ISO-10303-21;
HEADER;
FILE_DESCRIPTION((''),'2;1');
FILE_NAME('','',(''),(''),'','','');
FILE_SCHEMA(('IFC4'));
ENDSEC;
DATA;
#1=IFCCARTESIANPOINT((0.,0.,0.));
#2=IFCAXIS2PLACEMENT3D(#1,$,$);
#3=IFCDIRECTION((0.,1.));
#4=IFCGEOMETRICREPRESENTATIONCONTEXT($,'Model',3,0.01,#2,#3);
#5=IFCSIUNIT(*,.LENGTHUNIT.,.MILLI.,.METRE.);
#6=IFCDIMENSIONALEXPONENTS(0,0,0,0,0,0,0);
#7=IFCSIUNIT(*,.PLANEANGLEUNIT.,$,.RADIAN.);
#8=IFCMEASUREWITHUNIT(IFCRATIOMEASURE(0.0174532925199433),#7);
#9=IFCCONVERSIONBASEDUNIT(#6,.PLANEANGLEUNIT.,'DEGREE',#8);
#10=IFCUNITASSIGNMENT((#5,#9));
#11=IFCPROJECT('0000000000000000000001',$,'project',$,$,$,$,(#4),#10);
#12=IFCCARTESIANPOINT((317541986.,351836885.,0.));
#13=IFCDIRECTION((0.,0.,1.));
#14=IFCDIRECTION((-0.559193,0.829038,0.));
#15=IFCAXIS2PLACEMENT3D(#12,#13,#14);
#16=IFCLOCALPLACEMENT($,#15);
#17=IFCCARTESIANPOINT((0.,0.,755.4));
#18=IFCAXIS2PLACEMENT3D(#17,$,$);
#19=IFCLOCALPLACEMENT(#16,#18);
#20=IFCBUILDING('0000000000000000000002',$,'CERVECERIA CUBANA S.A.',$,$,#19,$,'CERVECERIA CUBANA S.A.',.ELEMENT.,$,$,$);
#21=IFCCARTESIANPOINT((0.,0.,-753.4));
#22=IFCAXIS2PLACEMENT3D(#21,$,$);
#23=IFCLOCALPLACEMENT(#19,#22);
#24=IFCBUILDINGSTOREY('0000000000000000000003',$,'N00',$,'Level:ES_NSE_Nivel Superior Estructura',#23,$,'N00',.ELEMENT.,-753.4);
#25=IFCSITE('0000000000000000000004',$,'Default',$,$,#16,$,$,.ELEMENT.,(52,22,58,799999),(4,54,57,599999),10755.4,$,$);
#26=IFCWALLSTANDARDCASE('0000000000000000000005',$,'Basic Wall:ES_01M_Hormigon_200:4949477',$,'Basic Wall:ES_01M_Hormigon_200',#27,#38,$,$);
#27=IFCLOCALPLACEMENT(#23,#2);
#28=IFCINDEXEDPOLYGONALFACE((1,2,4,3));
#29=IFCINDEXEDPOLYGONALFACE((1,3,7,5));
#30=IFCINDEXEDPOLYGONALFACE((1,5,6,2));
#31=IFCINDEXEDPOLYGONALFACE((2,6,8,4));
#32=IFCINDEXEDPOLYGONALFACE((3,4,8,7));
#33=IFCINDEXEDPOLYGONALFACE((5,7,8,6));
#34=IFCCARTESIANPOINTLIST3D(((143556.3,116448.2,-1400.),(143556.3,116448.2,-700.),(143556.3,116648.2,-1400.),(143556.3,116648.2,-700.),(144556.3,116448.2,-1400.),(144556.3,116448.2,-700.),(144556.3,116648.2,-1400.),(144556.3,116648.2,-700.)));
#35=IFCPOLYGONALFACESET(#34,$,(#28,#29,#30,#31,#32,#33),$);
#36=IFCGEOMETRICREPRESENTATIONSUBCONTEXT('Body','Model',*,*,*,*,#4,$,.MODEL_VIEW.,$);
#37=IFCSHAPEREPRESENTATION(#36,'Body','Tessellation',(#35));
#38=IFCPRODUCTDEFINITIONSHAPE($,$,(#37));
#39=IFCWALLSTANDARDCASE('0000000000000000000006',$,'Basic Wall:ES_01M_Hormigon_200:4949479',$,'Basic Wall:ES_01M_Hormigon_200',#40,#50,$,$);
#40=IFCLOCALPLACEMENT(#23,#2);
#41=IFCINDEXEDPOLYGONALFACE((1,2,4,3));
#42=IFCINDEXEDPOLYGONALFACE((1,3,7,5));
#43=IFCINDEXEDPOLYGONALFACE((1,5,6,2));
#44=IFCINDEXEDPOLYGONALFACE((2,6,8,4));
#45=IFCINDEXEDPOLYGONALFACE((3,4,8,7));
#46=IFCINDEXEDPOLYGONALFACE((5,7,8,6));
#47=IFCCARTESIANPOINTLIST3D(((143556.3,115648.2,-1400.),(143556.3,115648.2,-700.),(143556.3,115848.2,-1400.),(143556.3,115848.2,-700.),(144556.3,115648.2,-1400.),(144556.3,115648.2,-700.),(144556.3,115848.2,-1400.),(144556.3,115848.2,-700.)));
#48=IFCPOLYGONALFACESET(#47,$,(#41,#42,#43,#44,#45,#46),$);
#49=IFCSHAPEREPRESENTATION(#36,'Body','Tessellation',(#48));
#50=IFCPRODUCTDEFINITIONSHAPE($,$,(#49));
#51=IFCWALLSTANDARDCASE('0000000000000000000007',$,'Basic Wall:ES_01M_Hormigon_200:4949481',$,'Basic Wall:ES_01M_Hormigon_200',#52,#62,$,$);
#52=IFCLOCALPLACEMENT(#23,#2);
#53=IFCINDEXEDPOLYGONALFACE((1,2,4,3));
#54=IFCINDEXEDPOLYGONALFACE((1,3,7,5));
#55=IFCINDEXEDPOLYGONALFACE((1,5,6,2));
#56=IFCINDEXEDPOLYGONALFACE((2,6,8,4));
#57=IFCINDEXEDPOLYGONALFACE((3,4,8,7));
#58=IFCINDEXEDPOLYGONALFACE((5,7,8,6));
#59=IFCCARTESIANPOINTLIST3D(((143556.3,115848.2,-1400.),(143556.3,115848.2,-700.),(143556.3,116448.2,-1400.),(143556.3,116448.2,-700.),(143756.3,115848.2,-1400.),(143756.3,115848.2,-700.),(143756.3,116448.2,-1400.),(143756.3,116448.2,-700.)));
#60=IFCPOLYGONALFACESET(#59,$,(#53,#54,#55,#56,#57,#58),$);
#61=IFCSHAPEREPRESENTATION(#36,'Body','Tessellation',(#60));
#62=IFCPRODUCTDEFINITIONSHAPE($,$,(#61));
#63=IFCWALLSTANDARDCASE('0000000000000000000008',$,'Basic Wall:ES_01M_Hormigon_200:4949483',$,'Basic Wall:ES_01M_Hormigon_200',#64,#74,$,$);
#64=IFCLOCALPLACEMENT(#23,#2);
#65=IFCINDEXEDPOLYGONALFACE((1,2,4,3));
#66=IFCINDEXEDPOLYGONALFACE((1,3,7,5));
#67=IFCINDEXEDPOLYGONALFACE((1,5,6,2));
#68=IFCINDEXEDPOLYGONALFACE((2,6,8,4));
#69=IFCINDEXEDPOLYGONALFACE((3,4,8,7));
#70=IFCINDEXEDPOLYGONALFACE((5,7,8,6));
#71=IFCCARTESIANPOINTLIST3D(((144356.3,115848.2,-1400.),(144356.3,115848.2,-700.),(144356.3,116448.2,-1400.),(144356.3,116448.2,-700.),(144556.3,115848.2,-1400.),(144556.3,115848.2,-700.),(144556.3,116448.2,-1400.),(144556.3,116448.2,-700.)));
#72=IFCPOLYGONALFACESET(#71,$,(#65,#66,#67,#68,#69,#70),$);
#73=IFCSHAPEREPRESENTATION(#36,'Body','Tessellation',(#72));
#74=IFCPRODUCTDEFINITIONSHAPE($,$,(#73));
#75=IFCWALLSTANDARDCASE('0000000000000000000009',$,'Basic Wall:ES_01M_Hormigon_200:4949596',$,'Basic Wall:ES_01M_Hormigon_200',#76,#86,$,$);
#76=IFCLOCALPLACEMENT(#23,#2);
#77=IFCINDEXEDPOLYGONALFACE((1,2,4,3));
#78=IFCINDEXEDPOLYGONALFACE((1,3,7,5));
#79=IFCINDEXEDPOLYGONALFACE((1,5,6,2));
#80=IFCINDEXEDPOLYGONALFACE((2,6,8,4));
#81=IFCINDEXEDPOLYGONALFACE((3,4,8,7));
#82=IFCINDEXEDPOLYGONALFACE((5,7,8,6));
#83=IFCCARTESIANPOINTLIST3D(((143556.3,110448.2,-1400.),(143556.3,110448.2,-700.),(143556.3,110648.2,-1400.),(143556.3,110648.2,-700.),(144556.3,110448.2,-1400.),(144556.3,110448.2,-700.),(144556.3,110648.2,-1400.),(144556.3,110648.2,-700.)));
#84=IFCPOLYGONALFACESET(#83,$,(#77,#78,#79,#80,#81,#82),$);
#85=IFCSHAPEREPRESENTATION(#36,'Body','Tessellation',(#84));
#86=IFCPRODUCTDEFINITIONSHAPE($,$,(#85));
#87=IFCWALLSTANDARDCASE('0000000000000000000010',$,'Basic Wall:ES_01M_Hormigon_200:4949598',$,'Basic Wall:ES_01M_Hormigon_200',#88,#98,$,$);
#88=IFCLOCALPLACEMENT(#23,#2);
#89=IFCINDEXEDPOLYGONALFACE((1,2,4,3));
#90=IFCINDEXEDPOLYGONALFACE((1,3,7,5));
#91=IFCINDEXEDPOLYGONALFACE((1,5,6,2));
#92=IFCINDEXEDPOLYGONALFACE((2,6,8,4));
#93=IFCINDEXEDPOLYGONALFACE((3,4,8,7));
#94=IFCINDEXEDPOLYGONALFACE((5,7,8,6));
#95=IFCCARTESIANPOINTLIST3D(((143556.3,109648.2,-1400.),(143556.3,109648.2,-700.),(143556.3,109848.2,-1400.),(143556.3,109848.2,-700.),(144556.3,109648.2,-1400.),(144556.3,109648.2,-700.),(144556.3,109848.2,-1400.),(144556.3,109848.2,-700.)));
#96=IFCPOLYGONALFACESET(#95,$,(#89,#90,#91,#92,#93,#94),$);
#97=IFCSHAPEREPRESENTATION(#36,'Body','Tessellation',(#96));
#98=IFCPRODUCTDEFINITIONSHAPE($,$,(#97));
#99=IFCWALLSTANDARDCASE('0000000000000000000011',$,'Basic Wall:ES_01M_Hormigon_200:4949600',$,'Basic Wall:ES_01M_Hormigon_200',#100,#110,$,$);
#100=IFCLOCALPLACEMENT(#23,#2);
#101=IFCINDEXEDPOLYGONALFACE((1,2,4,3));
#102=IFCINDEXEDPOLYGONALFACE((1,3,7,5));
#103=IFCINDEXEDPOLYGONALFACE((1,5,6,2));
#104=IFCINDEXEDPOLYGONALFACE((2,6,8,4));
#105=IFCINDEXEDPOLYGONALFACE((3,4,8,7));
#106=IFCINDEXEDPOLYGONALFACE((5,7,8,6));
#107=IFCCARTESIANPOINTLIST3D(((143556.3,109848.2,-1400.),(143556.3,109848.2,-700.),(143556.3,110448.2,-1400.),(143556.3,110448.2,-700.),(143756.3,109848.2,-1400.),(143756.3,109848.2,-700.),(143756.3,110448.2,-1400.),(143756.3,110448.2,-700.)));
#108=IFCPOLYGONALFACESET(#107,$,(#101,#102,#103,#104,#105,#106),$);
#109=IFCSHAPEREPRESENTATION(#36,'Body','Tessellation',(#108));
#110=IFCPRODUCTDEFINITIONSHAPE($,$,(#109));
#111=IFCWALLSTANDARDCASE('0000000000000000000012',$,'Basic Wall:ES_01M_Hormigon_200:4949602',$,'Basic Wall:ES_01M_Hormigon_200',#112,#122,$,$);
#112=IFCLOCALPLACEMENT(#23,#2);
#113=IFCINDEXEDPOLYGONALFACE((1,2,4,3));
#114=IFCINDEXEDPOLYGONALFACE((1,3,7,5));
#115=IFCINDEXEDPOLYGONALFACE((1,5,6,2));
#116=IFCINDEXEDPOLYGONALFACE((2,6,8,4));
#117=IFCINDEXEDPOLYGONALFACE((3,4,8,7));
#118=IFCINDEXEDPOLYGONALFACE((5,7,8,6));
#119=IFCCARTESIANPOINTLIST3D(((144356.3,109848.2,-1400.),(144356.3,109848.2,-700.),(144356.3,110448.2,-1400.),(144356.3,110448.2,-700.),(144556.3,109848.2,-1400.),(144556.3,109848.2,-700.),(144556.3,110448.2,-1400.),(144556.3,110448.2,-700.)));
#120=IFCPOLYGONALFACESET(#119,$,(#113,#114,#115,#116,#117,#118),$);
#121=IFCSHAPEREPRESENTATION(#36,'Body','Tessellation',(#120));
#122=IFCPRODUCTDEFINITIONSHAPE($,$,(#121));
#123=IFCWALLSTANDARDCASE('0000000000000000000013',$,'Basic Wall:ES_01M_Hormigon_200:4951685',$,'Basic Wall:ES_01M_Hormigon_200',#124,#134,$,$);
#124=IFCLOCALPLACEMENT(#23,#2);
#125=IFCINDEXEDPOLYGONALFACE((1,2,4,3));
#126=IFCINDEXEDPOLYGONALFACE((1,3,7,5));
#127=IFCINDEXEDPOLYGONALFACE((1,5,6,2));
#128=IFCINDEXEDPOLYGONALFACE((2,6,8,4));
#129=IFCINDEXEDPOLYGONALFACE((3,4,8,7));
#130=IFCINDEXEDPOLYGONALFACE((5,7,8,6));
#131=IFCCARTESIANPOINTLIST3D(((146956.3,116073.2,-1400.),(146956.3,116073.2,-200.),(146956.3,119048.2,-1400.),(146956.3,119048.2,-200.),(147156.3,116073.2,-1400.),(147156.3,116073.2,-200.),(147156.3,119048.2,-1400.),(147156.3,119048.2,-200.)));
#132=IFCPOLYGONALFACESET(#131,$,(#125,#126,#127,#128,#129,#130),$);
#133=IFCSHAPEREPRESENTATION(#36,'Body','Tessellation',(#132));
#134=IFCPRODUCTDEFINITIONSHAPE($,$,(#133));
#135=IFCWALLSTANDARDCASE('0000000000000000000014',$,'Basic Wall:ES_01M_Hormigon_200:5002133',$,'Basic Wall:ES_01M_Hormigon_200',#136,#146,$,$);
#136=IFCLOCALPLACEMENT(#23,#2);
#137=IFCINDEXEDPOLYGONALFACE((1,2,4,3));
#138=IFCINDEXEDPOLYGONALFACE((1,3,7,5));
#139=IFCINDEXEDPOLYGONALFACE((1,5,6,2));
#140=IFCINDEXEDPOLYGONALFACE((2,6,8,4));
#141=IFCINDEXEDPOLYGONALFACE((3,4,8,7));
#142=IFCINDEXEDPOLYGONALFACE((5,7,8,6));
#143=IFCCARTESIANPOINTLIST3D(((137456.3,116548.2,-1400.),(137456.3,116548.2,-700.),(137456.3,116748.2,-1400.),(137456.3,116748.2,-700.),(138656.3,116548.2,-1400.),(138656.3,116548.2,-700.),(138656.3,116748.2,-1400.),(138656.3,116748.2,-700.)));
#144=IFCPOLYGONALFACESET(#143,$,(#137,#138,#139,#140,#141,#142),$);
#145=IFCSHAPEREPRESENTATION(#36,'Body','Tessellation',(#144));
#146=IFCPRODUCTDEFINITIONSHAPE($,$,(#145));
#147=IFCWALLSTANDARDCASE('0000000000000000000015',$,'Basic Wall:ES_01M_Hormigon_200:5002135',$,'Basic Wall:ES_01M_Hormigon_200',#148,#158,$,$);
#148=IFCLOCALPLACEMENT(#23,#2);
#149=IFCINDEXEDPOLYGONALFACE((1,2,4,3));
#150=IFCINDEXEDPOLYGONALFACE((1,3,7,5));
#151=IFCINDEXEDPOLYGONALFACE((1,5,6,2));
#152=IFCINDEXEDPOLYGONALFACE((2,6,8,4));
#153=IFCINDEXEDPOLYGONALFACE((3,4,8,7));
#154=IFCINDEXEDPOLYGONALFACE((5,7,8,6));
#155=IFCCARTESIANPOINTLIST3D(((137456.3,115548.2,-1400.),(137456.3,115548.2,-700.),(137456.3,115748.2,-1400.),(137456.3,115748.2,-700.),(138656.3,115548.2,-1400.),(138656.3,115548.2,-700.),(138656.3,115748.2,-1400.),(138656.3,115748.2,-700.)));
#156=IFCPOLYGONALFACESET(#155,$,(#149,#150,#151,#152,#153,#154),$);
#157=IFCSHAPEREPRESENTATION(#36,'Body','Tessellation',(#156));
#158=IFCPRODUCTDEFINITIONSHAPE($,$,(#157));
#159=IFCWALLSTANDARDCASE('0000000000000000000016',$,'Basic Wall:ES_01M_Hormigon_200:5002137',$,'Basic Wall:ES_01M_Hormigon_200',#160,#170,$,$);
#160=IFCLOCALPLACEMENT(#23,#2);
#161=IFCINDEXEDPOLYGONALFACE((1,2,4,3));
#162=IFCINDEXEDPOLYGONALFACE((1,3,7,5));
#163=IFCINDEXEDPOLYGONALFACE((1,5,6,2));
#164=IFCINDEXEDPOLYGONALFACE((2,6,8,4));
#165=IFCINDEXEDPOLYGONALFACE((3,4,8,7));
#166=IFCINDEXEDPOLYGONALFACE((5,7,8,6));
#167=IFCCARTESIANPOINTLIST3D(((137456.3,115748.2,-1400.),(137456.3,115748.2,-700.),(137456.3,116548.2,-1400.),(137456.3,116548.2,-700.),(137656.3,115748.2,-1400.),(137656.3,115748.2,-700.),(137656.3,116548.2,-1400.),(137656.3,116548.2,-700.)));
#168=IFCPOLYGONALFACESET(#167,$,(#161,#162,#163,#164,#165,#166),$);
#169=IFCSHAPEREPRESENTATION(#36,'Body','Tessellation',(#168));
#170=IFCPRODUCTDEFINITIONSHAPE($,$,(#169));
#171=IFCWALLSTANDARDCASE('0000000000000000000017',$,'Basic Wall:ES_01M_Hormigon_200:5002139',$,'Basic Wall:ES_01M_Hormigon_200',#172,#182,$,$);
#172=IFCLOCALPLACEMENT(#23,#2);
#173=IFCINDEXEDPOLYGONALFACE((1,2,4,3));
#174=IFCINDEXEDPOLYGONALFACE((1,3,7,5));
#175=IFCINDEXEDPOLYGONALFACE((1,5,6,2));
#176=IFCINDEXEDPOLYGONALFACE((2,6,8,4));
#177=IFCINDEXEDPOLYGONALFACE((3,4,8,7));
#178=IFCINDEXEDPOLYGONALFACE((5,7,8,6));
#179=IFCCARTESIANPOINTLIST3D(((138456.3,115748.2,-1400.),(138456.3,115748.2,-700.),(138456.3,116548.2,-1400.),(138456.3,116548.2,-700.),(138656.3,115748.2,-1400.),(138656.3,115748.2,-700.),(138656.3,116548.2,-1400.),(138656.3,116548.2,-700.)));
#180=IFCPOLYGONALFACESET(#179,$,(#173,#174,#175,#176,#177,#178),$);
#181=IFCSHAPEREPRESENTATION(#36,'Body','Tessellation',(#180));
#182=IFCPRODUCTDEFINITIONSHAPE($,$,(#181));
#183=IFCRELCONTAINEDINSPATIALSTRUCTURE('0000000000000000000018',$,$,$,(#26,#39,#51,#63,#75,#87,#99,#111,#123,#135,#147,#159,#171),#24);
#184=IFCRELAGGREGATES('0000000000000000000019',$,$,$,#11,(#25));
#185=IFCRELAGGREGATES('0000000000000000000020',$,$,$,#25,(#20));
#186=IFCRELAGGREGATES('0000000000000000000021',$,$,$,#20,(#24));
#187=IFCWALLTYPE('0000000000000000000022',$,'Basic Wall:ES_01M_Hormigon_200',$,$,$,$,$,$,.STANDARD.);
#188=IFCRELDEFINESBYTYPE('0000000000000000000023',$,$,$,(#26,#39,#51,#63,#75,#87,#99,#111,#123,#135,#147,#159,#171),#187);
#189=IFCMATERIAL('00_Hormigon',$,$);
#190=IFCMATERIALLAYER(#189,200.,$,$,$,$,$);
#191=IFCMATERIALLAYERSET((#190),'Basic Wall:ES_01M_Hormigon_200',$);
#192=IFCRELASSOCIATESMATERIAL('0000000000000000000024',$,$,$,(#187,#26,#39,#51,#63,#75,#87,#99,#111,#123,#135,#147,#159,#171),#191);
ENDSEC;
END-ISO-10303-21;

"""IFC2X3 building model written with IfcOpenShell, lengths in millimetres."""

from ifc_helpers import new_model, entity, si_unit, converted_unit, direction, frame, frame_2d, origin, place, context, subcontext, project, spatial, polyline, rectangle, extrude, clip, bounded_halfspace, material, layer, layer_set, layer_usage, type_object, element, save


model = new_model("IFC2X3")

# Units and contexts
model_context = context("Model", 3, precision=0.01, world=origin(), true_north=direction((0.0, 1.0)))
body_context = subcontext(model_context, "Body", "Model", "MODEL_VIEW")
ifc_project = project(units=[si_unit("LENGTHUNIT", "METRE", prefix="MILLI"), converted_unit("PLANEANGLEUNIT", "DEGREE", entity("IfcRatioMeasure", 0.0174532925199433), si_unit("PLANEANGLEUNIT", "RADIAN"), dimensions=[0, 0, 0, 0, 0, 0, 0])], contexts=[model_context])

# Site, building, storey
site_placement = place(None, frame((317541986.0, 351836885.0, 0.0), z_axis=(0.0, 0.0, 1.0), x_axis=(-0.559193, 0.829038, 0.0)))
site = spatial("IfcSite", under=ifc_project, at=site_placement, Name="Default", CompositionType="ELEMENT", RefLatitude=(52, 22, 58, 799999), RefLongitude=(4, 54, 57, 599999), RefElevation=10755.4)
building_placement = place(site_placement, frame((0.0, 0.0, 755.4)))
building = spatial("IfcBuilding", under=site, at=building_placement, Name="CERVECERIA CUBANA S.A.", LongName="CERVECERIA CUBANA S.A.", CompositionType="ELEMENT")
storey_placement = place(building_placement, frame((0.0, 0.0, -753.4)))
storey = spatial("IfcBuildingStorey", under=building, at=storey_placement, Name="N00", ObjectType="Level:ES_NSE_Nivel Superior Estructura", LongName="N00", CompositionType="ELEMENT", Elevation=-753.4)

# Walls
ifc_material = material(Name="00_Hormigon")
ifc_layer_1 = layer(ifc_material, 200.0)
ifc_layer_set_1 = layer_set([ifc_layer_1], Name="Basic Wall:ES_01M_Hormigon_200")
ifc_layer_usage_1 = layer_usage(ifc_layer_set_1, "AXIS2", "NEGATIVE", 100.0)
wall_type_1 = type_object("IfcWallType", Name="Basic Wall:ES_01M_Hormigon_200", PredefinedType="STANDARD", material=ifc_layer_set_1)
wall_1_placement = place(storey_placement, frame((143556.3, 116548.2, -1400.0)))
element("IfcWallStandardCase", 1, at=wall_1_placement, inside=storey, type_object=wall_type_1, material=ifc_layer_usage_1, Name="Basic Wall:ES_01M_Hormigon_200:4949477", ObjectType="Basic Wall:ES_01M_Hormigon_200", context=body_context, shape_type="SweptSolid", body=[
    extrude(rectangle(XDim=1000.0, YDim=200.0, at=frame_2d((500.0, 0.0), x_axis=(-1.0, 0.0))), origin(), (0.0, 0.0, 1.0), 700.0),
])
ifc_layer_usage_2 = layer_usage(ifc_layer_set_1, "AXIS2", "POSITIVE", -100.0)
wall_2_placement = place(storey_placement, frame((143556.3, 115748.2, -1400.0)))
element("IfcWallStandardCase", 2, at=wall_2_placement, inside=storey, type_object=wall_type_1, material=ifc_layer_usage_2, Name="Basic Wall:ES_01M_Hormigon_200:4949479", ObjectType="Basic Wall:ES_01M_Hormigon_200", context=body_context, shape_type="SweptSolid", body=[
    extrude(rectangle(XDim=1000.0, YDim=200.0, at=frame_2d((500.0, 0.0), x_axis=(-1.0, 0.0))), origin(), (0.0, 0.0, 1.0), 700.0),
])
ifc_layer_usage_3 = layer_usage(ifc_layer_set_1, "AXIS2", "POSITIVE", -100.0)
wall_3_placement = place(storey_placement, frame((143656.3, 116448.2, -1400.0), z_axis=(0.0, 0.0, 1.0), x_axis=(0.0, -1.0, 0.0)))
element("IfcWallStandardCase", 3, at=wall_3_placement, inside=storey, type_object=wall_type_1, material=ifc_layer_usage_3, Name="Basic Wall:ES_01M_Hormigon_200:4949481", ObjectType="Basic Wall:ES_01M_Hormigon_200", context=body_context, shape_type="SweptSolid", body=[
    extrude(rectangle(XDim=600.0, YDim=200.0, at=frame_2d((300.0, 0.0), x_axis=(-1.0, 0.0))), origin(), (0.0, 0.0, 1.0), 700.0),
])
ifc_layer_usage_4 = layer_usage(ifc_layer_set_1, "AXIS2", "NEGATIVE", 100.0)
wall_4_placement = place(storey_placement, frame((144456.3, 116448.2, -1400.0), z_axis=(0.0, 0.0, 1.0), x_axis=(0.0, -1.0, 0.0)))
element("IfcWallStandardCase", 4, at=wall_4_placement, inside=storey, type_object=wall_type_1, material=ifc_layer_usage_4, Name="Basic Wall:ES_01M_Hormigon_200:4949483", ObjectType="Basic Wall:ES_01M_Hormigon_200", context=body_context, shape_type="SweptSolid", body=[
    extrude(rectangle(XDim=600.0, YDim=200.0, at=frame_2d((300.0, 0.0), x_axis=(-1.0, 0.0))), origin(), (0.0, 0.0, 1.0), 700.0),
])
ifc_layer_usage_5 = layer_usage(ifc_layer_set_1, "AXIS2", "NEGATIVE", 100.0)
wall_5_placement = place(storey_placement, frame((143556.3, 110548.2, -1400.0)))
element("IfcWallStandardCase", 5, at=wall_5_placement, inside=storey, type_object=wall_type_1, material=ifc_layer_usage_5, Name="Basic Wall:ES_01M_Hormigon_200:4949596", ObjectType="Basic Wall:ES_01M_Hormigon_200", context=body_context, shape_type="SweptSolid", body=[
    extrude(rectangle(XDim=1000.0, YDim=200.0, at=frame_2d((500.0, 0.0), x_axis=(-1.0, 0.0))), origin(), (0.0, 0.0, 1.0), 700.0),
])
ifc_layer_usage_6 = layer_usage(ifc_layer_set_1, "AXIS2", "POSITIVE", -100.0)
wall_6_placement = place(storey_placement, frame((143556.3, 109748.2, -1400.0)))
element("IfcWallStandardCase", 6, at=wall_6_placement, inside=storey, type_object=wall_type_1, material=ifc_layer_usage_6, Name="Basic Wall:ES_01M_Hormigon_200:4949598", ObjectType="Basic Wall:ES_01M_Hormigon_200", context=body_context, shape_type="SweptSolid", body=[
    extrude(rectangle(XDim=1000.0, YDim=200.0, at=frame_2d((500.0, 0.0), x_axis=(-1.0, 0.0))), origin(), (0.0, 0.0, 1.0), 700.0),
])
ifc_layer_usage_7 = layer_usage(ifc_layer_set_1, "AXIS2", "POSITIVE", -100.0)
wall_7_placement = place(storey_placement, frame((143656.3, 110448.2, -1400.0), z_axis=(0.0, 0.0, 1.0), x_axis=(0.0, -1.0, 0.0)))
element("IfcWallStandardCase", 7, at=wall_7_placement, inside=storey, type_object=wall_type_1, material=ifc_layer_usage_7, Name="Basic Wall:ES_01M_Hormigon_200:4949600", ObjectType="Basic Wall:ES_01M_Hormigon_200", context=body_context, shape_type="SweptSolid", body=[
    extrude(rectangle(XDim=600.0, YDim=200.0, at=frame_2d((300.0, 0.0), x_axis=(-1.0, 0.0))), origin(), (0.0, 0.0, 1.0), 700.0),
])
ifc_layer_usage_8 = layer_usage(ifc_layer_set_1, "AXIS2", "NEGATIVE", 100.0)
wall_8_placement = place(storey_placement, frame((144456.3, 110448.2, -1400.0), z_axis=(0.0, 0.0, 1.0), x_axis=(0.0, -1.0, 0.0)))
element("IfcWallStandardCase", 8, at=wall_8_placement, inside=storey, type_object=wall_type_1, material=ifc_layer_usage_8, Name="Basic Wall:ES_01M_Hormigon_200:4949602", ObjectType="Basic Wall:ES_01M_Hormigon_200", context=body_context, shape_type="SweptSolid", body=[
    extrude(rectangle(XDim=600.0, YDim=200.0, at=frame_2d((300.0, 0.0), x_axis=(-1.0, 0.0))), origin(), (0.0, 0.0, 1.0), 700.0),
])
ifc_layer_usage_9 = layer_usage(ifc_layer_set_1, "AXIS2", "NEGATIVE", 100.0)
wall_9_placement = place(storey_placement, frame((147056.3, 119048.2, -1400.0), z_axis=(0.0, 0.0, 1.0), x_axis=(0.0, -1.0, 0.0)))
element("IfcWallStandardCase", 9, at=wall_9_placement, inside=storey, type_object=wall_type_1, material=ifc_layer_usage_9, Name="Basic Wall:ES_01M_Hormigon_200:4951685", ObjectType="Basic Wall:ES_01M_Hormigon_200", context=body_context, shape_type="Clipping", body=[
    clip(extrude(rectangle(XDim=2975.0, YDim=200.0, at=frame_2d((1487.5, 0.0), x_axis=(-1.0, 0.0))), origin(), (0.0, 0.0, 1.0), 1200.0), bounded_halfspace(frame((0.0, -100.0, 1200.0), z_axis=(0.0, 0.0, -1.0), x_axis=(-1.0, 0.0, 0.0)), True, frame((0.0, -100.0, 1200.0), z_axis=(0.0, 0.0, -1.0), x_axis=(-1.0, 0.0, 0.0)), polyline([(0.0, 0.0), (0.0, 200.0), (-2975.0, 200.0), (-2975.0, 0.0), (0.0, 0.0)]))),
])
ifc_layer_usage_10 = layer_usage(ifc_layer_set_1, "AXIS2", "NEGATIVE", 100.0)
wall_10_placement = place(storey_placement, frame((137456.3, 116648.2, -1400.0)))
element("IfcWallStandardCase", 10, at=wall_10_placement, inside=storey, type_object=wall_type_1, material=ifc_layer_usage_10, Name="Basic Wall:ES_01M_Hormigon_200:5002133", ObjectType="Basic Wall:ES_01M_Hormigon_200", context=body_context, shape_type="SweptSolid", body=[
    extrude(rectangle(XDim=1200.0, YDim=200.0, at=frame_2d((600.0, 0.0), x_axis=(-1.0, 0.0))), origin(), (0.0, 0.0, 1.0), 700.0),
])
ifc_layer_usage_11 = layer_usage(ifc_layer_set_1, "AXIS2", "POSITIVE", -100.0)
wall_11_placement = place(storey_placement, frame((137456.3, 115648.2, -1400.0)))
element("IfcWallStandardCase", 11, at=wall_11_placement, inside=storey, type_object=wall_type_1, material=ifc_layer_usage_11, Name="Basic Wall:ES_01M_Hormigon_200:5002135", ObjectType="Basic Wall:ES_01M_Hormigon_200", context=body_context, shape_type="SweptSolid", body=[
    extrude(rectangle(XDim=1200.0, YDim=200.0, at=frame_2d((600.0, 0.0), x_axis=(-1.0, 0.0))), origin(), (0.0, 0.0, 1.0), 700.0),
])
ifc_layer_usage_12 = layer_usage(ifc_layer_set_1, "AXIS2", "POSITIVE", -100.0)
wall_12_placement = place(storey_placement, frame((137556.3, 116548.2, -1400.0), z_axis=(0.0, 0.0, 1.0), x_axis=(0.0, -1.0, 0.0)))
element("IfcWallStandardCase", 12, at=wall_12_placement, inside=storey, type_object=wall_type_1, material=ifc_layer_usage_12, Name="Basic Wall:ES_01M_Hormigon_200:5002137", ObjectType="Basic Wall:ES_01M_Hormigon_200", context=body_context, shape_type="SweptSolid", body=[
    extrude(rectangle(XDim=800.0, YDim=200.0, at=frame_2d((400.0, 0.0), x_axis=(-1.0, 0.0))), origin(), (0.0, 0.0, 1.0), 700.0),
])
ifc_layer_usage_13 = layer_usage(ifc_layer_set_1, "AXIS2", "NEGATIVE", 100.0)
wall_13_placement = place(storey_placement, frame((138556.3, 116548.2, -1400.0), z_axis=(0.0, 0.0, 1.0), x_axis=(0.0, -1.0, 0.0)))
element("IfcWallStandardCase", 13, at=wall_13_placement, inside=storey, type_object=wall_type_1, material=ifc_layer_usage_13, Name="Basic Wall:ES_01M_Hormigon_200:5002139", ObjectType="Basic Wall:ES_01M_Hormigon_200", context=body_context, shape_type="SweptSolid", body=[
    extrude(rectangle(XDim=800.0, YDim=200.0, at=frame_2d((400.0, 0.0), x_axis=(-1.0, 0.0))), origin(), (0.0, 0.0, 1.0), 700.0),
])

save(model, "model.ifc")
